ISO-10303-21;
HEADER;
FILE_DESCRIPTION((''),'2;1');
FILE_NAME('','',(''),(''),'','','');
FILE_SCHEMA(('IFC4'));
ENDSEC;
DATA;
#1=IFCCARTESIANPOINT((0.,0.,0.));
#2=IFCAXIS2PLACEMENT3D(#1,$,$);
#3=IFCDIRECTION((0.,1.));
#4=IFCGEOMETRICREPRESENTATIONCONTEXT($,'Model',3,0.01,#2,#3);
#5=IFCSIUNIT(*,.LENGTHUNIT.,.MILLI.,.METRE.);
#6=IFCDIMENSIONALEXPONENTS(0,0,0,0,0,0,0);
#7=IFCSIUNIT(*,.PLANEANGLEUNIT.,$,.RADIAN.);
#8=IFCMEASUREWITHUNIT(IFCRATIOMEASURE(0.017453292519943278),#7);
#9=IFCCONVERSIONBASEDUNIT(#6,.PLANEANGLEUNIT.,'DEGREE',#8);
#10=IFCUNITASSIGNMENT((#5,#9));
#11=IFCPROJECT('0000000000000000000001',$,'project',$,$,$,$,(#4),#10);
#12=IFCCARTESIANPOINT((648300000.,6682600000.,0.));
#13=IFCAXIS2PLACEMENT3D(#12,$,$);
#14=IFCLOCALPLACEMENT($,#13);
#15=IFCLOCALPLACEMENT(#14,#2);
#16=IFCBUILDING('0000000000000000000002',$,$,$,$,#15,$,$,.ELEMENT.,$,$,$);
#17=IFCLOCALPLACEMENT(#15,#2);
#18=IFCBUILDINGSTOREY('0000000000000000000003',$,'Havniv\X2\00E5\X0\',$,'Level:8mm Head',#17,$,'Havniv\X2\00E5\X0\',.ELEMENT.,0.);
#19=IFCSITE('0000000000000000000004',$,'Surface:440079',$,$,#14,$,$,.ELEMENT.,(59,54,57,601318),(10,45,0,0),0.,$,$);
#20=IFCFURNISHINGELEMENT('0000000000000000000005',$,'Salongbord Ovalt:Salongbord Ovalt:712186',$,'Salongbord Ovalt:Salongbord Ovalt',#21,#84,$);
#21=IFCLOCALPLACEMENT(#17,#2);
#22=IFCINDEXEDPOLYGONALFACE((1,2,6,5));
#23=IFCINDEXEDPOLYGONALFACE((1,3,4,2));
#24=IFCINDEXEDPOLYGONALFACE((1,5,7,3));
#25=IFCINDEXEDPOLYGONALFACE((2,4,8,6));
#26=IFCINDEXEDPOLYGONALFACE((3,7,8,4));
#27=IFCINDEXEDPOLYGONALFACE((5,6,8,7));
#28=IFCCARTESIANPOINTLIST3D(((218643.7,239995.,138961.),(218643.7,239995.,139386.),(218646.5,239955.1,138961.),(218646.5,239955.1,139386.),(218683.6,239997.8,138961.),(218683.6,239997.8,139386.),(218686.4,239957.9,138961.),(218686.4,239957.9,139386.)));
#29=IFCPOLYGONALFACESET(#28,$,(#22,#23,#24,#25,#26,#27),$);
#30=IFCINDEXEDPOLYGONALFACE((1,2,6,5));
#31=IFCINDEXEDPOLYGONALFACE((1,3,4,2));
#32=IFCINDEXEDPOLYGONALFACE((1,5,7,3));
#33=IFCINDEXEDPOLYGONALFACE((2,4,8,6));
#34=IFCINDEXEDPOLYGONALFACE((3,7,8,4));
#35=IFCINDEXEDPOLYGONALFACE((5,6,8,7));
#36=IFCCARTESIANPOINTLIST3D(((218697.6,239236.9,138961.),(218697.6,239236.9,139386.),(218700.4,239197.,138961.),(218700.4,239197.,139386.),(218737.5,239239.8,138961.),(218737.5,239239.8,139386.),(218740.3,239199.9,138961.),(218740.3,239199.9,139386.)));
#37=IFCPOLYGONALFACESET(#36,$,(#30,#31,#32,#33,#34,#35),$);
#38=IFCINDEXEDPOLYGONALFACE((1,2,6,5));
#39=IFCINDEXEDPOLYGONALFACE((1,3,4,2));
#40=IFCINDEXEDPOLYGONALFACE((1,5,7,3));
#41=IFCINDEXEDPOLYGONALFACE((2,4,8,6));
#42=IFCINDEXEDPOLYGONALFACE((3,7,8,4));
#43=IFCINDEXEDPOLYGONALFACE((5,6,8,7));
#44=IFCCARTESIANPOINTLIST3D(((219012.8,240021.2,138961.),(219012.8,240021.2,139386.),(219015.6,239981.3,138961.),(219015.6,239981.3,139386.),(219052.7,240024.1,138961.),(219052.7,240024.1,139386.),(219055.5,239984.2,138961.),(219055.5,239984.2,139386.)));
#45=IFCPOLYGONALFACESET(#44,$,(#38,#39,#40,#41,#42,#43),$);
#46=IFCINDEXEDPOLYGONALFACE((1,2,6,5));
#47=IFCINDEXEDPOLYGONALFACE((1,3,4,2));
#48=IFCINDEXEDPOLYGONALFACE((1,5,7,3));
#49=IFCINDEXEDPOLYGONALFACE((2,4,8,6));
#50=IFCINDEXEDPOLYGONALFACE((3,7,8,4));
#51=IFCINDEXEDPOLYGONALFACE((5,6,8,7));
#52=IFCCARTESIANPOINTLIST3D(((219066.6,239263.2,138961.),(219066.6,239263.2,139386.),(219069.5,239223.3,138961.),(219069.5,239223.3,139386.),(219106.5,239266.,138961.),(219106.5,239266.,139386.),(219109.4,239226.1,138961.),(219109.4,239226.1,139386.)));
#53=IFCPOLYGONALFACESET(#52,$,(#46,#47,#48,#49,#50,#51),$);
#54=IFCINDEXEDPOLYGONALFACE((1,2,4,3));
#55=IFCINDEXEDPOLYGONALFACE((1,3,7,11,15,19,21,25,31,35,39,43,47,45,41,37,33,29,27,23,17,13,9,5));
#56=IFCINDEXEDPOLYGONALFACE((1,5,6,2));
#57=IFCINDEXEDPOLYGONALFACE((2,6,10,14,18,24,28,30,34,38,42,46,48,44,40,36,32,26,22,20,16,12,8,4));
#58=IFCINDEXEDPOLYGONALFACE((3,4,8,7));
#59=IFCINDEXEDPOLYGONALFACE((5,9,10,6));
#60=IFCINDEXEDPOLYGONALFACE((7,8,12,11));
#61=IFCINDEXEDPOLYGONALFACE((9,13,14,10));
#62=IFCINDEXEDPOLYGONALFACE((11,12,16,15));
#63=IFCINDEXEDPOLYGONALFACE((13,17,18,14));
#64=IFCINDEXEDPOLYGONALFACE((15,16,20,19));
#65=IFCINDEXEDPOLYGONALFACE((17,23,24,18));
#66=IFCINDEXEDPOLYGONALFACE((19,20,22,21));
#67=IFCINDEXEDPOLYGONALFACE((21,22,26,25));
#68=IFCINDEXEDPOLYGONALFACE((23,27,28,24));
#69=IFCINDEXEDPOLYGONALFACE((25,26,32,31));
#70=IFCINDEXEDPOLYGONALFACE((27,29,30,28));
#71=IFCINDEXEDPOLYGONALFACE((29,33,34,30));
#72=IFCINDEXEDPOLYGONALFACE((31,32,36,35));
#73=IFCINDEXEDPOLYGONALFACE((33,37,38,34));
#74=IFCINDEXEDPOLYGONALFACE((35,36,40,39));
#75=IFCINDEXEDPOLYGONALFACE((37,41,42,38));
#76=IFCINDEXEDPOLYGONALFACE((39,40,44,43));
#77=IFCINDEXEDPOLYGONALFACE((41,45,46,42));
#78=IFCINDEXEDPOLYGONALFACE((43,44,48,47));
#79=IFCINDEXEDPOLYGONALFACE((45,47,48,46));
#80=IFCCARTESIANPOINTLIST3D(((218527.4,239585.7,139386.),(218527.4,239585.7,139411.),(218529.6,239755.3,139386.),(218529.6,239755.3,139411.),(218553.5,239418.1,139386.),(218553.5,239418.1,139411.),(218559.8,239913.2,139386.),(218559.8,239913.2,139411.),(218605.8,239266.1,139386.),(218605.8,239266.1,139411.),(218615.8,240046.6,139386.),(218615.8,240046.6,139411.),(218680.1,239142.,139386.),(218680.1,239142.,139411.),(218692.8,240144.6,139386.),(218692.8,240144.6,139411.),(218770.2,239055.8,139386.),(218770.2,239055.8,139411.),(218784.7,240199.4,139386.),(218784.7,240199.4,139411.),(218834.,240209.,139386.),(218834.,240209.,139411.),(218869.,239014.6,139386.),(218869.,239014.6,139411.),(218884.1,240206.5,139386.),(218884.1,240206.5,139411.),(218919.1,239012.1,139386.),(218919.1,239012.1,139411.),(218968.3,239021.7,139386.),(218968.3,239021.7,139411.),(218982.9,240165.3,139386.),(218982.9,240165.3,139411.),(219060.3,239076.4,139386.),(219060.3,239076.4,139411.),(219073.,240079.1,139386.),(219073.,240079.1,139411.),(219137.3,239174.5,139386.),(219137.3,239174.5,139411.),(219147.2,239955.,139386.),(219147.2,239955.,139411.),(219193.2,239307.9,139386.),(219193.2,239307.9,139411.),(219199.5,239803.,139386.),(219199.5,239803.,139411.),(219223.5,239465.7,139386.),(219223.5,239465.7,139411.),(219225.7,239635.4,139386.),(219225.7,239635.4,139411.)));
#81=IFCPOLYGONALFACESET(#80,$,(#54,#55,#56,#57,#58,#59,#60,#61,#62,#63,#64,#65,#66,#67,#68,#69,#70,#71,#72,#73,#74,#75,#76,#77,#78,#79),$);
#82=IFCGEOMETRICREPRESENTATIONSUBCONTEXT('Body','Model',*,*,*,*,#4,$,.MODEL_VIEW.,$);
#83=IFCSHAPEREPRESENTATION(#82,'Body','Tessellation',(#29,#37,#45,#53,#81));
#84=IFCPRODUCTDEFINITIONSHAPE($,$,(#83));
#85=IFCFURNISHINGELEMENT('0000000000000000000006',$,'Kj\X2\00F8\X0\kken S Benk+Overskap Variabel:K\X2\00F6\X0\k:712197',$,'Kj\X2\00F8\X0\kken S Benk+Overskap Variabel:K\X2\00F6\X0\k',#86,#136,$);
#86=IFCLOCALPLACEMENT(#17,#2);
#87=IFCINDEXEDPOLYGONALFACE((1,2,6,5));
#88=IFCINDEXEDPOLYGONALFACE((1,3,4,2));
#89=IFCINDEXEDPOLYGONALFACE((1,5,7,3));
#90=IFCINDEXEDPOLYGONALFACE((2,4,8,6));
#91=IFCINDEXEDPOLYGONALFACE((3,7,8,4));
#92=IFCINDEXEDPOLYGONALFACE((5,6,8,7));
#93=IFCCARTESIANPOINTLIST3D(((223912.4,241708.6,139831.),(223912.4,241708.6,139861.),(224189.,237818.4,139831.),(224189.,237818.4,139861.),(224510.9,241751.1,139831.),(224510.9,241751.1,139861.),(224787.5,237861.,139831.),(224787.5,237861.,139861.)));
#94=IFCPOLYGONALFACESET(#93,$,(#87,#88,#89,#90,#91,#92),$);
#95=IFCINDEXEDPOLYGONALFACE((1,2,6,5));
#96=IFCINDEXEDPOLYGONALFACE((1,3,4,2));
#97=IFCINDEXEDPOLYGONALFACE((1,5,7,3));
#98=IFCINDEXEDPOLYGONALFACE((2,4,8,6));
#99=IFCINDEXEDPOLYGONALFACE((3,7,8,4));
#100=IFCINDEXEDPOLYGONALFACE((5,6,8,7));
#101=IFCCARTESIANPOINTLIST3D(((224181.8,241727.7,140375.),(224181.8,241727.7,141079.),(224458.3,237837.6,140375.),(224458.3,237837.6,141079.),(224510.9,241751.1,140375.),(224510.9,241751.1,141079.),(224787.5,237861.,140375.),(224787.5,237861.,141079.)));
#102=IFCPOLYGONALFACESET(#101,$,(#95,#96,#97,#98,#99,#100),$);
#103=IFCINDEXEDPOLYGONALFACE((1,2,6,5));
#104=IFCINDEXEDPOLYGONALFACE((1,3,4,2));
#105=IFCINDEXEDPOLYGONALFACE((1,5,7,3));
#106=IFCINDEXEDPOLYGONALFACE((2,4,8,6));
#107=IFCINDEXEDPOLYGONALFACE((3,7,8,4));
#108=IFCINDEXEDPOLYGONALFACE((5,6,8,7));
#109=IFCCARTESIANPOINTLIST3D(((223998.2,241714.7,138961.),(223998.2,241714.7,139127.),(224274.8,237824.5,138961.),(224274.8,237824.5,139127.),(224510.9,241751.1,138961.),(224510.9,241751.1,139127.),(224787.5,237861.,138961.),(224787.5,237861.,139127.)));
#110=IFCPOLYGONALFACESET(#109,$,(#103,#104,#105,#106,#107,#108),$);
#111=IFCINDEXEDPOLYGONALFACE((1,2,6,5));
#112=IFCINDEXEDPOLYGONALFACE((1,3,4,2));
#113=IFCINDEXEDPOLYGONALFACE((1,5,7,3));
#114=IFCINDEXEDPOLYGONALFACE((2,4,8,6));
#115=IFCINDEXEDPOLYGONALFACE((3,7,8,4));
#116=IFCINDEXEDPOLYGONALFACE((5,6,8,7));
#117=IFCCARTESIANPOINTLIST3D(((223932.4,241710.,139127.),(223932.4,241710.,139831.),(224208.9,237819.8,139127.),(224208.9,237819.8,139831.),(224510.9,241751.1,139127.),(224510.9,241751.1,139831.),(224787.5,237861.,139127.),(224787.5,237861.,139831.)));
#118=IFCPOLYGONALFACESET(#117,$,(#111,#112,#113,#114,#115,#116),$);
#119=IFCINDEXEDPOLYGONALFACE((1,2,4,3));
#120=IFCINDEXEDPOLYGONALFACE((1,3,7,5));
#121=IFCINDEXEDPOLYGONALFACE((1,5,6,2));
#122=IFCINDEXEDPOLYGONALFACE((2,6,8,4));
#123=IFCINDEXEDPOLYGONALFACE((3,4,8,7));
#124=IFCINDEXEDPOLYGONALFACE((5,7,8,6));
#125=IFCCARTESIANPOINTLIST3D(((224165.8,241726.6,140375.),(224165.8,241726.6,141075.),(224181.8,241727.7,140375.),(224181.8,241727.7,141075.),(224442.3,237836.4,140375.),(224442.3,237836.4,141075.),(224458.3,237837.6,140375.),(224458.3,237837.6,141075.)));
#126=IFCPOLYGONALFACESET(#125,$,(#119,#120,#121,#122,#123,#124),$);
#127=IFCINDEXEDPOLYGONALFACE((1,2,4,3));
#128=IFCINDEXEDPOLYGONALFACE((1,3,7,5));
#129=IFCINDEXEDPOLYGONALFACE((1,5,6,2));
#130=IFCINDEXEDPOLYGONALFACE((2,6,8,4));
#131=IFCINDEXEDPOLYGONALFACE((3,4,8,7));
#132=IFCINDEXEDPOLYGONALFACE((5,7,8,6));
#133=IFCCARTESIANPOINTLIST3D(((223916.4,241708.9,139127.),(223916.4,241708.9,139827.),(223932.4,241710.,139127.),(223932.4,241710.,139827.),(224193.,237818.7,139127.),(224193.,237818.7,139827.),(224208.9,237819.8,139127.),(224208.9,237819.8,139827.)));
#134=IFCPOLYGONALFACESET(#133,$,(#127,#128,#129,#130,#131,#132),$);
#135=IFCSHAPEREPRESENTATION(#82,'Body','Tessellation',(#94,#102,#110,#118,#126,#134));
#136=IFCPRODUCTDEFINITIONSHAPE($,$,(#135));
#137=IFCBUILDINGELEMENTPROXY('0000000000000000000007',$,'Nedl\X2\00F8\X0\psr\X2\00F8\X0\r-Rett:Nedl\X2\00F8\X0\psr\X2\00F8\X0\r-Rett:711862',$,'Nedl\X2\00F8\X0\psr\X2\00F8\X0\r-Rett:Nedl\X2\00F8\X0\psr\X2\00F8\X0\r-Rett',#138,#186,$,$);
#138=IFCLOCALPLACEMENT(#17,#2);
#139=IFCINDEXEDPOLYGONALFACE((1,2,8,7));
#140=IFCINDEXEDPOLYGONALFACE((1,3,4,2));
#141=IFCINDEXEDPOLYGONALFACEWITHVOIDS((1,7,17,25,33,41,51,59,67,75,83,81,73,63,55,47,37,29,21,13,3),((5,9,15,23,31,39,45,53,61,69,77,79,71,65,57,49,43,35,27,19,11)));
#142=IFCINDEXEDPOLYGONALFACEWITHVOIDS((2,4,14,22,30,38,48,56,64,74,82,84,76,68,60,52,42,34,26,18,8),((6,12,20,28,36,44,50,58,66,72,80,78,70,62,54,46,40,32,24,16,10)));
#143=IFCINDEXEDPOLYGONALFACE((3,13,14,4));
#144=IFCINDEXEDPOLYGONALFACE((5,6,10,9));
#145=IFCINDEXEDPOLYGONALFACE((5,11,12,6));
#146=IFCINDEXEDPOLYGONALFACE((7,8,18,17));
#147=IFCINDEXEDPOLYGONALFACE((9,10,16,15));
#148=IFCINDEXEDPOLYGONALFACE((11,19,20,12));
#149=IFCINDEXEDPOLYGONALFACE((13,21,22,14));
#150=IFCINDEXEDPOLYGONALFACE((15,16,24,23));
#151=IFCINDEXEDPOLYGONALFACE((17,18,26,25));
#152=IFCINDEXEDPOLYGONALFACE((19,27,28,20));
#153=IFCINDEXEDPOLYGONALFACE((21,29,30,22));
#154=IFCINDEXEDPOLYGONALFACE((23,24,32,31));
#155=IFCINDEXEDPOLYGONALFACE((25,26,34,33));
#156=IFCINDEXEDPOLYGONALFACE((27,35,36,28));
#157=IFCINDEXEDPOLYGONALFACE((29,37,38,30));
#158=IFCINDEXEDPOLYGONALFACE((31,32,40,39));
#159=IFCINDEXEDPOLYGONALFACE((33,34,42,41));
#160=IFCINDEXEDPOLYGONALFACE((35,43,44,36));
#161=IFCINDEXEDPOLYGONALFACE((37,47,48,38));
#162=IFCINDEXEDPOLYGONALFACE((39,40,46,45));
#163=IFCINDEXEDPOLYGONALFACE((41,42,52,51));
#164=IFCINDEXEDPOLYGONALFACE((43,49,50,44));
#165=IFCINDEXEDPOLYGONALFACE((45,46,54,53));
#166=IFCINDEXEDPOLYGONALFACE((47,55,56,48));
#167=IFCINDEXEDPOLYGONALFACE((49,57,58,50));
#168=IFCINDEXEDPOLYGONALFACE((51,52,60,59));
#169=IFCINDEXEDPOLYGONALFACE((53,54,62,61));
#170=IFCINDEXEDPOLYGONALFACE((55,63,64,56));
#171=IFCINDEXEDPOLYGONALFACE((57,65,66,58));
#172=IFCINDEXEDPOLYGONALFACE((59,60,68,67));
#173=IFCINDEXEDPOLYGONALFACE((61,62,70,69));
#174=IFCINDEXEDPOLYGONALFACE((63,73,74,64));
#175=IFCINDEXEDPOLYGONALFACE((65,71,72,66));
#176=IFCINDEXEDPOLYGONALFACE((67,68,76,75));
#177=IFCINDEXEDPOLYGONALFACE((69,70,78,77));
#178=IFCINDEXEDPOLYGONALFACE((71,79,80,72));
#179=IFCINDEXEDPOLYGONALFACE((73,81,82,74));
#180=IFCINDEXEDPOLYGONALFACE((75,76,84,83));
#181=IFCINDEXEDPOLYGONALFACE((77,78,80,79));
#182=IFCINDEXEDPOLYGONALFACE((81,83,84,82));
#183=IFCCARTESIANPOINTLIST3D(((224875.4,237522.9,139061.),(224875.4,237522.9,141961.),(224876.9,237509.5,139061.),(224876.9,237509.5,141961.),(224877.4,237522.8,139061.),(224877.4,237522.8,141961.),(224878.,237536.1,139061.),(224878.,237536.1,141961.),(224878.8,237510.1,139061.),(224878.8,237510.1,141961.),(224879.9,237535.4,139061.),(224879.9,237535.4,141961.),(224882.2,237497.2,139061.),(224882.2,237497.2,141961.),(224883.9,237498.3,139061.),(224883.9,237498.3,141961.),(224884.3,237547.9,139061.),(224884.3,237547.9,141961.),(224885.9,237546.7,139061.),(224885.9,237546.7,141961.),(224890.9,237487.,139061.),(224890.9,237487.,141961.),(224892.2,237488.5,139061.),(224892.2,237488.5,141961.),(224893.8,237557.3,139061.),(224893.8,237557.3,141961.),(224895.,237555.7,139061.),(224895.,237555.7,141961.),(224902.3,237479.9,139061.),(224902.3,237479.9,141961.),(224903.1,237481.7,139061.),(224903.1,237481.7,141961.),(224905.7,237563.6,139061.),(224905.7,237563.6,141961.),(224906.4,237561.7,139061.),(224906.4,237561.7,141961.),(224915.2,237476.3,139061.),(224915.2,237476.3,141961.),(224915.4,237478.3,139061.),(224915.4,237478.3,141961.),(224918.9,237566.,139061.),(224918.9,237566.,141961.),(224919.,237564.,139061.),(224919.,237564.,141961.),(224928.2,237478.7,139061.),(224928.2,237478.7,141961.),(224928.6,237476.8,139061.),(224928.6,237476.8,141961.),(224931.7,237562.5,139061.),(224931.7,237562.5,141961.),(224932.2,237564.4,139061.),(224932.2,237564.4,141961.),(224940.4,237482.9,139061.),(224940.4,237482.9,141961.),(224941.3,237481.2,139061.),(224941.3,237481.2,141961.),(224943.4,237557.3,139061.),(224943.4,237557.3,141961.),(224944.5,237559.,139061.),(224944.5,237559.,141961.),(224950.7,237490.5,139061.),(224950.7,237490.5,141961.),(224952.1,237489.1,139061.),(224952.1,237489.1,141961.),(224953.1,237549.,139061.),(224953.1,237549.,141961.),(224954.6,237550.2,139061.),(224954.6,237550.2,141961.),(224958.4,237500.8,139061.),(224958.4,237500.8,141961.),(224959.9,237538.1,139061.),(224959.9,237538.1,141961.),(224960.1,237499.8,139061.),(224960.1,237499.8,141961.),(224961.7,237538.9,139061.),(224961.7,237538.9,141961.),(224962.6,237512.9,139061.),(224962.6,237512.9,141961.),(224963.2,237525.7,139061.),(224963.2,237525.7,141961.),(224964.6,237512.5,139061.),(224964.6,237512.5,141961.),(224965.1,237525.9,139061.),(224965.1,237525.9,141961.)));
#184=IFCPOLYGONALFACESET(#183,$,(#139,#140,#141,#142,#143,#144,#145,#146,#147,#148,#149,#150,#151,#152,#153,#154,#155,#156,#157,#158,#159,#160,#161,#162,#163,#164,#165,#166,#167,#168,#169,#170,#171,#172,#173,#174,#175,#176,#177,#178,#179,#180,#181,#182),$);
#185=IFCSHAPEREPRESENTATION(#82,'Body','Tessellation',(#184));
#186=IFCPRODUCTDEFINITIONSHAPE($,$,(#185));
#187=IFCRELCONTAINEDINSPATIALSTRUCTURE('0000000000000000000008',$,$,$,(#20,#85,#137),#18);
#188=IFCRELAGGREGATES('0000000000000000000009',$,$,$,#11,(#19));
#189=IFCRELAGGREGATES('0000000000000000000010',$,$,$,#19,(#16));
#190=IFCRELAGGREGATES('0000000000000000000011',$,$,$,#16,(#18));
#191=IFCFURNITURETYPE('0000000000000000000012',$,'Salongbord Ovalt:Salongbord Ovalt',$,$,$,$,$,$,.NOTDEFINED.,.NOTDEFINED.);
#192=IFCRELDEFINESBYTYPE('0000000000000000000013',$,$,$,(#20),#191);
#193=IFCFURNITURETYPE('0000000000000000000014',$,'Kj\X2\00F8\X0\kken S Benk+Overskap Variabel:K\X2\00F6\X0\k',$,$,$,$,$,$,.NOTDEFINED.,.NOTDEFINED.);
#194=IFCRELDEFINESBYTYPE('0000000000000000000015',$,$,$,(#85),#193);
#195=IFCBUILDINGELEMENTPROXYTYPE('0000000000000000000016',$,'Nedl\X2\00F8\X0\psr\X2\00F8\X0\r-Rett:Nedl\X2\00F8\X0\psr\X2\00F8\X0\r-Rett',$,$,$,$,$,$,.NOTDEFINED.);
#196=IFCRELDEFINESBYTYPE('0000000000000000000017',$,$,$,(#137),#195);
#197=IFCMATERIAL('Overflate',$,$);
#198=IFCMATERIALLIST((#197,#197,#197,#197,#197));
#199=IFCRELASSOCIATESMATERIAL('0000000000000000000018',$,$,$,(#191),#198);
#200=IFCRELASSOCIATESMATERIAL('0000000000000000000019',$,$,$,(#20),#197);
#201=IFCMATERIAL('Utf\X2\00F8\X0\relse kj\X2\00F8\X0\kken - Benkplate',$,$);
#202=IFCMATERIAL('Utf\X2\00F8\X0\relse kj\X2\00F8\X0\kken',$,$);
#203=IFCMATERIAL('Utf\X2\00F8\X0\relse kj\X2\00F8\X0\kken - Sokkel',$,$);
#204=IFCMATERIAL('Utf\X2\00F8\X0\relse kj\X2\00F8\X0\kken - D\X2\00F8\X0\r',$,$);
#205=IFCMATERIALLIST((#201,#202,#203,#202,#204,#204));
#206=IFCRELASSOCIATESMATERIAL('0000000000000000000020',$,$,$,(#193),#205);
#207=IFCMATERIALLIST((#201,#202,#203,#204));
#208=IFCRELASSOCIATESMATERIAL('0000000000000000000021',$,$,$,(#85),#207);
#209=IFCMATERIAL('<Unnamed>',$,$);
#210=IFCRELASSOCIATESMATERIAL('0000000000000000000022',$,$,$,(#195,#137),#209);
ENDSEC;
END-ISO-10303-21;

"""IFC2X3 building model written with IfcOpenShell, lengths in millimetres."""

from ifc_helpers import new_model, entity, si_unit, converted_unit, direction, frame, frame_2d, origin, origin_2d_with_axis, place, context, subcontext, project, spatial, polyline, rectangle, hollow_circle, outline, extrude, source, transform, mapped, material, material_list, type_object, type_shapes, element, save


model = new_model("IFC2X3")

# Units and contexts
model_context = context("Model", 3, precision=0.01, world=origin(), true_north=direction((0.0, 1.0)))
body_context = subcontext(model_context, "Body", "Model", "MODEL_VIEW")
ifc_project = project(units=[si_unit("LENGTHUNIT", "METRE", prefix="MILLI"), converted_unit("PLANEANGLEUNIT", "DEGREE", entity("IfcRatioMeasure", 0.017453292519943278), si_unit("PLANEANGLEUNIT", "RADIAN"), dimensions=[0, 0, 0, 0, 0, 0, 0])], contexts=[model_context])

# Site, building, storey
site_placement = place(None, frame((648300000.0, 6682600000.0, 0.0)))
site = spatial("IfcSite", under=ifc_project, at=site_placement, Name="Surface:440079", CompositionType="ELEMENT", RefLatitude=(59, 54, 57, 601318), RefLongitude=(10, 45, 0, 0), RefElevation=0.0)
building_placement = place(site_placement, origin())
building = spatial("IfcBuilding", under=site, at=building_placement, CompositionType="ELEMENT")
storey_placement = place(building_placement, origin())
storey = spatial("IfcBuildingStorey", under=building, at=storey_placement, Name="Havnivå", ObjectType="Level:8mm Head", LongName="Havnivå", CompositionType="ELEMENT", Elevation=0.0)

# Furnishing elements
ifc_material_1 = material(Name="Overflate")
ifc_material_list_1 = material_list([ifc_material_1, ifc_material_1, ifc_material_1, ifc_material_1, ifc_material_1])
furniture_type_1 = type_object("IfcFurnitureType", Name="Salongbord Ovalt:Salongbord Ovalt", material=ifc_material_list_1)
shared_shape_1 = source(origin(), body_context, "Body", "SweptSolid", [
    extrude(rectangle(XDim=40.0, YDim=40.0, at=origin_2d_with_axis()), frame((380.0, 185.0, 0.0), z_axis=(0.0, 0.0, 1.0), x_axis=(-1.0, 0.0, 0.0)), (0.0, 0.0, 1.0), 425.0),
    extrude(rectangle(XDim=40.0, YDim=40.0, at=origin_2d_with_axis()), frame((-380.0, 185.0, 0.0), z_axis=(0.0, 0.0, 1.0), x_axis=(-1.0, 0.0, 0.0)), (0.0, 0.0, 1.0), 425.0),
    extrude(rectangle(XDim=40.0, YDim=40.0, at=origin_2d_with_axis()), frame((380.0, -185.0, 0.0), z_axis=(0.0, 0.0, 1.0), x_axis=(-1.0, 0.0, 0.0)), (0.0, 0.0, 1.0), 425.0),
    extrude(rectangle(XDim=40.0, YDim=40.0, at=origin_2d_with_axis()), frame((-380.0, -185.0, 0.0), z_axis=(0.0, 0.0, 1.0), x_axis=(-1.0, 0.0, 0.0)), (0.0, 0.0, 1.0), 425.0),
    extrude(outline(polyline([(-73.0, -595.5), (-22.8, -595.5), (77.9, -559.4), (172.3, -478.0), (252.8, -357.8), (312.8, -208.7), (347.4, -42.6), (353.9, 126.9), (331.7, 286.1), (282.7, 422.2), (210.7, 524.0), (121.7, 583.4), (73.0, 595.5), (22.8, 595.5), (-77.9, 559.4), (-172.3, 478.0), (-252.8, 357.8), (-312.8, 208.7), (-347.4, 42.6), (-353.9, -126.9), (-331.7, -286.1), (-282.7, -422.2), (-210.7, -524.0), (-121.7, -583.4), (-73.0, -595.5)])), frame((0.0, 0.0, 425.0), z_axis=(0.0, 0.0, 1.0), x_axis=(0.121697, -0.992567, 0.0)), (0.0, 0.0, 1.0), 25.0),
])
type_shapes(furniture_type_1, [shared_shape_1])
for number, where, z_axis, x_axis, name in (
    (1, (218876.5, 239610.5, 138961.0), (0.0, 0.0, 1.0), (-0.070908, 0.997483, 0.0), "Salongbord Ovalt:Salongbord Ovalt:712186"),
):
    element("IfcFurnishingElement", number, at=place(storey_placement, frame(where, z_axis=z_axis, x_axis=x_axis)), inside=storey, type_object=furniture_type_1, material=ifc_material_1, Name=name, ObjectType="Salongbord Ovalt:Salongbord Ovalt", context=body_context, shape_type="MappedRepresentation", body=[
        mapped(shared_shape_1, transform((0.0, 0.0, 0.0), scale=1.0)),
    ])
ifc_material_2 = material(Name="Utførelse kjøkken - Benkplate")
ifc_material_3 = material(Name="Utførelse kjøkken")
ifc_material_4 = material(Name="Utførelse kjøkken - Sokkel")
ifc_material_5 = material(Name="Utførelse kjøkken - Dør")
ifc_material_list_2 = material_list([ifc_material_2, ifc_material_3, ifc_material_4, ifc_material_5])
ifc_material_list_3 = material_list([ifc_material_2, ifc_material_3, ifc_material_4, ifc_material_3, ifc_material_5, ifc_material_5])
furniture_type_2 = type_object("IfcFurnitureType", Name="Kjøkken S Benk+Overskap Variabel:Kök", material=ifc_material_list_3)
shared_shape_2 = source(origin(), body_context, "Body", "SweptSolid", [
    extrude(rectangle(XDim=600.0, YDim=3900.0, at=origin_2d_with_axis()), frame((1950.0, 300.0, 870.0), z_axis=(0.0, 0.0, 1.0), x_axis=(0.0, 1.0, 0.0)), (0.0, 0.0, 1.0), 30.0),
    extrude(rectangle(XDim=330.0, YDim=3900.0, at=origin_2d_with_axis()), frame((1950.0, 165.0, 1414.0), z_axis=(0.0, 0.0, 1.0), x_axis=(0.0, 1.0, 0.0)), (0.0, 0.0, 1.0), 704.0),
    extrude(rectangle(XDim=514.0, YDim=3900.0, at=origin_2d_with_axis()), frame((1950.0, 257.0, 0.0), z_axis=(0.0, 0.0, 1.0), x_axis=(0.0, 1.0, 0.0)), (0.0, 0.0, 1.0), 166.0),
    extrude(rectangle(XDim=580.0, YDim=3900.0, at=origin_2d_with_axis()), frame((1950.0, 290.0, 166.0), z_axis=(0.0, 0.0, 1.0), x_axis=(0.0, 1.0, 0.0)), (0.0, 0.0, 1.0), 704.0),
    extrude(rectangle(XDim=16.0, YDim=3900.0, at=origin_2d_with_axis()), frame((1950.0, 338.0, 1414.0), z_axis=(0.0, 0.0, 1.0), x_axis=(0.0, -1.0, 0.0)), (0.0, 0.0, 1.0), 700.0),
    extrude(rectangle(XDim=16.0, YDim=3900.0, at=frame_2d((0.0, 0.0), x_axis=(1.0, 0.0))), frame((1950.0, 588.0, 166.0), z_axis=(0.0, 0.0, 1.0), x_axis=(0.0, -1.0, 0.0)), (0.0, 0.0, 1.0), 700.0),
])
type_shapes(furniture_type_2, [shared_shape_2])
furnishing_1_placement = place(storey_placement, frame((224787.5, 237861.0, 138961.0), z_axis=(0.0, 0.0, 1.0), x_axis=(-0.070908, 0.997483, 0.0)))
element("IfcFurnishingElement", 2, at=furnishing_1_placement, inside=storey, type_object=furniture_type_2, material=ifc_material_list_2, Name="Kjøkken S Benk+Overskap Variabel:Kök:712197", ObjectType="Kjøkken S Benk+Overskap Variabel:Kök", context=body_context, shape_type="MappedRepresentation", body=[
    mapped(shared_shape_2, transform((0.0, 0.0, 0.0), scale=1.0)),
])

# Building element proxy
ifc_material_6 = material(Name="<Unnamed>")
building_element_proxy_type_1 = type_object("IfcBuildingElementProxyType", Name="Nedløpsrør-Rett:Nedløpsrør-Rett", PredefinedType="NOTDEFINED", material=ifc_material_6)
shared_shape_3 = source(origin(), body_context, "Body", "SweptSolid", [
    extrude(hollow_circle(Radius=45.0, WallThickness=2.0, at=frame_2d((0.0, 0.0), x_axis=(1.0, 0.0))), frame((0.0, 0.0, 0.0), z_axis=(0.0, 0.0, 1.0), x_axis=(-1.0, 0.0, 0.0)), (0.0, 0.0, 1.0), 2900.0),
])
type_shapes(building_element_proxy_type_1, [shared_shape_3])
for number, where, z_axis, x_axis, name in (
    (3, (224920.4, 237521.0, 139061.0), (0.0, 0.0, 1.0), (0.655187, 0.755467, 0.0), "Nedløpsrør-Rett:Nedløpsrør-Rett:711862"),
):
    element("IfcBuildingElementProxy", number, at=place(storey_placement, frame(where, z_axis=z_axis, x_axis=x_axis)), inside=storey, type_object=building_element_proxy_type_1, material=ifc_material_6, Name=name, ObjectType="Nedløpsrør-Rett:Nedløpsrør-Rett", context=body_context, shape_type="MappedRepresentation", body=[
        mapped(shared_shape_3, transform((0.0, 0.0, 0.0), scale=1.0)),
    ])

save(model, "model.ifc")
